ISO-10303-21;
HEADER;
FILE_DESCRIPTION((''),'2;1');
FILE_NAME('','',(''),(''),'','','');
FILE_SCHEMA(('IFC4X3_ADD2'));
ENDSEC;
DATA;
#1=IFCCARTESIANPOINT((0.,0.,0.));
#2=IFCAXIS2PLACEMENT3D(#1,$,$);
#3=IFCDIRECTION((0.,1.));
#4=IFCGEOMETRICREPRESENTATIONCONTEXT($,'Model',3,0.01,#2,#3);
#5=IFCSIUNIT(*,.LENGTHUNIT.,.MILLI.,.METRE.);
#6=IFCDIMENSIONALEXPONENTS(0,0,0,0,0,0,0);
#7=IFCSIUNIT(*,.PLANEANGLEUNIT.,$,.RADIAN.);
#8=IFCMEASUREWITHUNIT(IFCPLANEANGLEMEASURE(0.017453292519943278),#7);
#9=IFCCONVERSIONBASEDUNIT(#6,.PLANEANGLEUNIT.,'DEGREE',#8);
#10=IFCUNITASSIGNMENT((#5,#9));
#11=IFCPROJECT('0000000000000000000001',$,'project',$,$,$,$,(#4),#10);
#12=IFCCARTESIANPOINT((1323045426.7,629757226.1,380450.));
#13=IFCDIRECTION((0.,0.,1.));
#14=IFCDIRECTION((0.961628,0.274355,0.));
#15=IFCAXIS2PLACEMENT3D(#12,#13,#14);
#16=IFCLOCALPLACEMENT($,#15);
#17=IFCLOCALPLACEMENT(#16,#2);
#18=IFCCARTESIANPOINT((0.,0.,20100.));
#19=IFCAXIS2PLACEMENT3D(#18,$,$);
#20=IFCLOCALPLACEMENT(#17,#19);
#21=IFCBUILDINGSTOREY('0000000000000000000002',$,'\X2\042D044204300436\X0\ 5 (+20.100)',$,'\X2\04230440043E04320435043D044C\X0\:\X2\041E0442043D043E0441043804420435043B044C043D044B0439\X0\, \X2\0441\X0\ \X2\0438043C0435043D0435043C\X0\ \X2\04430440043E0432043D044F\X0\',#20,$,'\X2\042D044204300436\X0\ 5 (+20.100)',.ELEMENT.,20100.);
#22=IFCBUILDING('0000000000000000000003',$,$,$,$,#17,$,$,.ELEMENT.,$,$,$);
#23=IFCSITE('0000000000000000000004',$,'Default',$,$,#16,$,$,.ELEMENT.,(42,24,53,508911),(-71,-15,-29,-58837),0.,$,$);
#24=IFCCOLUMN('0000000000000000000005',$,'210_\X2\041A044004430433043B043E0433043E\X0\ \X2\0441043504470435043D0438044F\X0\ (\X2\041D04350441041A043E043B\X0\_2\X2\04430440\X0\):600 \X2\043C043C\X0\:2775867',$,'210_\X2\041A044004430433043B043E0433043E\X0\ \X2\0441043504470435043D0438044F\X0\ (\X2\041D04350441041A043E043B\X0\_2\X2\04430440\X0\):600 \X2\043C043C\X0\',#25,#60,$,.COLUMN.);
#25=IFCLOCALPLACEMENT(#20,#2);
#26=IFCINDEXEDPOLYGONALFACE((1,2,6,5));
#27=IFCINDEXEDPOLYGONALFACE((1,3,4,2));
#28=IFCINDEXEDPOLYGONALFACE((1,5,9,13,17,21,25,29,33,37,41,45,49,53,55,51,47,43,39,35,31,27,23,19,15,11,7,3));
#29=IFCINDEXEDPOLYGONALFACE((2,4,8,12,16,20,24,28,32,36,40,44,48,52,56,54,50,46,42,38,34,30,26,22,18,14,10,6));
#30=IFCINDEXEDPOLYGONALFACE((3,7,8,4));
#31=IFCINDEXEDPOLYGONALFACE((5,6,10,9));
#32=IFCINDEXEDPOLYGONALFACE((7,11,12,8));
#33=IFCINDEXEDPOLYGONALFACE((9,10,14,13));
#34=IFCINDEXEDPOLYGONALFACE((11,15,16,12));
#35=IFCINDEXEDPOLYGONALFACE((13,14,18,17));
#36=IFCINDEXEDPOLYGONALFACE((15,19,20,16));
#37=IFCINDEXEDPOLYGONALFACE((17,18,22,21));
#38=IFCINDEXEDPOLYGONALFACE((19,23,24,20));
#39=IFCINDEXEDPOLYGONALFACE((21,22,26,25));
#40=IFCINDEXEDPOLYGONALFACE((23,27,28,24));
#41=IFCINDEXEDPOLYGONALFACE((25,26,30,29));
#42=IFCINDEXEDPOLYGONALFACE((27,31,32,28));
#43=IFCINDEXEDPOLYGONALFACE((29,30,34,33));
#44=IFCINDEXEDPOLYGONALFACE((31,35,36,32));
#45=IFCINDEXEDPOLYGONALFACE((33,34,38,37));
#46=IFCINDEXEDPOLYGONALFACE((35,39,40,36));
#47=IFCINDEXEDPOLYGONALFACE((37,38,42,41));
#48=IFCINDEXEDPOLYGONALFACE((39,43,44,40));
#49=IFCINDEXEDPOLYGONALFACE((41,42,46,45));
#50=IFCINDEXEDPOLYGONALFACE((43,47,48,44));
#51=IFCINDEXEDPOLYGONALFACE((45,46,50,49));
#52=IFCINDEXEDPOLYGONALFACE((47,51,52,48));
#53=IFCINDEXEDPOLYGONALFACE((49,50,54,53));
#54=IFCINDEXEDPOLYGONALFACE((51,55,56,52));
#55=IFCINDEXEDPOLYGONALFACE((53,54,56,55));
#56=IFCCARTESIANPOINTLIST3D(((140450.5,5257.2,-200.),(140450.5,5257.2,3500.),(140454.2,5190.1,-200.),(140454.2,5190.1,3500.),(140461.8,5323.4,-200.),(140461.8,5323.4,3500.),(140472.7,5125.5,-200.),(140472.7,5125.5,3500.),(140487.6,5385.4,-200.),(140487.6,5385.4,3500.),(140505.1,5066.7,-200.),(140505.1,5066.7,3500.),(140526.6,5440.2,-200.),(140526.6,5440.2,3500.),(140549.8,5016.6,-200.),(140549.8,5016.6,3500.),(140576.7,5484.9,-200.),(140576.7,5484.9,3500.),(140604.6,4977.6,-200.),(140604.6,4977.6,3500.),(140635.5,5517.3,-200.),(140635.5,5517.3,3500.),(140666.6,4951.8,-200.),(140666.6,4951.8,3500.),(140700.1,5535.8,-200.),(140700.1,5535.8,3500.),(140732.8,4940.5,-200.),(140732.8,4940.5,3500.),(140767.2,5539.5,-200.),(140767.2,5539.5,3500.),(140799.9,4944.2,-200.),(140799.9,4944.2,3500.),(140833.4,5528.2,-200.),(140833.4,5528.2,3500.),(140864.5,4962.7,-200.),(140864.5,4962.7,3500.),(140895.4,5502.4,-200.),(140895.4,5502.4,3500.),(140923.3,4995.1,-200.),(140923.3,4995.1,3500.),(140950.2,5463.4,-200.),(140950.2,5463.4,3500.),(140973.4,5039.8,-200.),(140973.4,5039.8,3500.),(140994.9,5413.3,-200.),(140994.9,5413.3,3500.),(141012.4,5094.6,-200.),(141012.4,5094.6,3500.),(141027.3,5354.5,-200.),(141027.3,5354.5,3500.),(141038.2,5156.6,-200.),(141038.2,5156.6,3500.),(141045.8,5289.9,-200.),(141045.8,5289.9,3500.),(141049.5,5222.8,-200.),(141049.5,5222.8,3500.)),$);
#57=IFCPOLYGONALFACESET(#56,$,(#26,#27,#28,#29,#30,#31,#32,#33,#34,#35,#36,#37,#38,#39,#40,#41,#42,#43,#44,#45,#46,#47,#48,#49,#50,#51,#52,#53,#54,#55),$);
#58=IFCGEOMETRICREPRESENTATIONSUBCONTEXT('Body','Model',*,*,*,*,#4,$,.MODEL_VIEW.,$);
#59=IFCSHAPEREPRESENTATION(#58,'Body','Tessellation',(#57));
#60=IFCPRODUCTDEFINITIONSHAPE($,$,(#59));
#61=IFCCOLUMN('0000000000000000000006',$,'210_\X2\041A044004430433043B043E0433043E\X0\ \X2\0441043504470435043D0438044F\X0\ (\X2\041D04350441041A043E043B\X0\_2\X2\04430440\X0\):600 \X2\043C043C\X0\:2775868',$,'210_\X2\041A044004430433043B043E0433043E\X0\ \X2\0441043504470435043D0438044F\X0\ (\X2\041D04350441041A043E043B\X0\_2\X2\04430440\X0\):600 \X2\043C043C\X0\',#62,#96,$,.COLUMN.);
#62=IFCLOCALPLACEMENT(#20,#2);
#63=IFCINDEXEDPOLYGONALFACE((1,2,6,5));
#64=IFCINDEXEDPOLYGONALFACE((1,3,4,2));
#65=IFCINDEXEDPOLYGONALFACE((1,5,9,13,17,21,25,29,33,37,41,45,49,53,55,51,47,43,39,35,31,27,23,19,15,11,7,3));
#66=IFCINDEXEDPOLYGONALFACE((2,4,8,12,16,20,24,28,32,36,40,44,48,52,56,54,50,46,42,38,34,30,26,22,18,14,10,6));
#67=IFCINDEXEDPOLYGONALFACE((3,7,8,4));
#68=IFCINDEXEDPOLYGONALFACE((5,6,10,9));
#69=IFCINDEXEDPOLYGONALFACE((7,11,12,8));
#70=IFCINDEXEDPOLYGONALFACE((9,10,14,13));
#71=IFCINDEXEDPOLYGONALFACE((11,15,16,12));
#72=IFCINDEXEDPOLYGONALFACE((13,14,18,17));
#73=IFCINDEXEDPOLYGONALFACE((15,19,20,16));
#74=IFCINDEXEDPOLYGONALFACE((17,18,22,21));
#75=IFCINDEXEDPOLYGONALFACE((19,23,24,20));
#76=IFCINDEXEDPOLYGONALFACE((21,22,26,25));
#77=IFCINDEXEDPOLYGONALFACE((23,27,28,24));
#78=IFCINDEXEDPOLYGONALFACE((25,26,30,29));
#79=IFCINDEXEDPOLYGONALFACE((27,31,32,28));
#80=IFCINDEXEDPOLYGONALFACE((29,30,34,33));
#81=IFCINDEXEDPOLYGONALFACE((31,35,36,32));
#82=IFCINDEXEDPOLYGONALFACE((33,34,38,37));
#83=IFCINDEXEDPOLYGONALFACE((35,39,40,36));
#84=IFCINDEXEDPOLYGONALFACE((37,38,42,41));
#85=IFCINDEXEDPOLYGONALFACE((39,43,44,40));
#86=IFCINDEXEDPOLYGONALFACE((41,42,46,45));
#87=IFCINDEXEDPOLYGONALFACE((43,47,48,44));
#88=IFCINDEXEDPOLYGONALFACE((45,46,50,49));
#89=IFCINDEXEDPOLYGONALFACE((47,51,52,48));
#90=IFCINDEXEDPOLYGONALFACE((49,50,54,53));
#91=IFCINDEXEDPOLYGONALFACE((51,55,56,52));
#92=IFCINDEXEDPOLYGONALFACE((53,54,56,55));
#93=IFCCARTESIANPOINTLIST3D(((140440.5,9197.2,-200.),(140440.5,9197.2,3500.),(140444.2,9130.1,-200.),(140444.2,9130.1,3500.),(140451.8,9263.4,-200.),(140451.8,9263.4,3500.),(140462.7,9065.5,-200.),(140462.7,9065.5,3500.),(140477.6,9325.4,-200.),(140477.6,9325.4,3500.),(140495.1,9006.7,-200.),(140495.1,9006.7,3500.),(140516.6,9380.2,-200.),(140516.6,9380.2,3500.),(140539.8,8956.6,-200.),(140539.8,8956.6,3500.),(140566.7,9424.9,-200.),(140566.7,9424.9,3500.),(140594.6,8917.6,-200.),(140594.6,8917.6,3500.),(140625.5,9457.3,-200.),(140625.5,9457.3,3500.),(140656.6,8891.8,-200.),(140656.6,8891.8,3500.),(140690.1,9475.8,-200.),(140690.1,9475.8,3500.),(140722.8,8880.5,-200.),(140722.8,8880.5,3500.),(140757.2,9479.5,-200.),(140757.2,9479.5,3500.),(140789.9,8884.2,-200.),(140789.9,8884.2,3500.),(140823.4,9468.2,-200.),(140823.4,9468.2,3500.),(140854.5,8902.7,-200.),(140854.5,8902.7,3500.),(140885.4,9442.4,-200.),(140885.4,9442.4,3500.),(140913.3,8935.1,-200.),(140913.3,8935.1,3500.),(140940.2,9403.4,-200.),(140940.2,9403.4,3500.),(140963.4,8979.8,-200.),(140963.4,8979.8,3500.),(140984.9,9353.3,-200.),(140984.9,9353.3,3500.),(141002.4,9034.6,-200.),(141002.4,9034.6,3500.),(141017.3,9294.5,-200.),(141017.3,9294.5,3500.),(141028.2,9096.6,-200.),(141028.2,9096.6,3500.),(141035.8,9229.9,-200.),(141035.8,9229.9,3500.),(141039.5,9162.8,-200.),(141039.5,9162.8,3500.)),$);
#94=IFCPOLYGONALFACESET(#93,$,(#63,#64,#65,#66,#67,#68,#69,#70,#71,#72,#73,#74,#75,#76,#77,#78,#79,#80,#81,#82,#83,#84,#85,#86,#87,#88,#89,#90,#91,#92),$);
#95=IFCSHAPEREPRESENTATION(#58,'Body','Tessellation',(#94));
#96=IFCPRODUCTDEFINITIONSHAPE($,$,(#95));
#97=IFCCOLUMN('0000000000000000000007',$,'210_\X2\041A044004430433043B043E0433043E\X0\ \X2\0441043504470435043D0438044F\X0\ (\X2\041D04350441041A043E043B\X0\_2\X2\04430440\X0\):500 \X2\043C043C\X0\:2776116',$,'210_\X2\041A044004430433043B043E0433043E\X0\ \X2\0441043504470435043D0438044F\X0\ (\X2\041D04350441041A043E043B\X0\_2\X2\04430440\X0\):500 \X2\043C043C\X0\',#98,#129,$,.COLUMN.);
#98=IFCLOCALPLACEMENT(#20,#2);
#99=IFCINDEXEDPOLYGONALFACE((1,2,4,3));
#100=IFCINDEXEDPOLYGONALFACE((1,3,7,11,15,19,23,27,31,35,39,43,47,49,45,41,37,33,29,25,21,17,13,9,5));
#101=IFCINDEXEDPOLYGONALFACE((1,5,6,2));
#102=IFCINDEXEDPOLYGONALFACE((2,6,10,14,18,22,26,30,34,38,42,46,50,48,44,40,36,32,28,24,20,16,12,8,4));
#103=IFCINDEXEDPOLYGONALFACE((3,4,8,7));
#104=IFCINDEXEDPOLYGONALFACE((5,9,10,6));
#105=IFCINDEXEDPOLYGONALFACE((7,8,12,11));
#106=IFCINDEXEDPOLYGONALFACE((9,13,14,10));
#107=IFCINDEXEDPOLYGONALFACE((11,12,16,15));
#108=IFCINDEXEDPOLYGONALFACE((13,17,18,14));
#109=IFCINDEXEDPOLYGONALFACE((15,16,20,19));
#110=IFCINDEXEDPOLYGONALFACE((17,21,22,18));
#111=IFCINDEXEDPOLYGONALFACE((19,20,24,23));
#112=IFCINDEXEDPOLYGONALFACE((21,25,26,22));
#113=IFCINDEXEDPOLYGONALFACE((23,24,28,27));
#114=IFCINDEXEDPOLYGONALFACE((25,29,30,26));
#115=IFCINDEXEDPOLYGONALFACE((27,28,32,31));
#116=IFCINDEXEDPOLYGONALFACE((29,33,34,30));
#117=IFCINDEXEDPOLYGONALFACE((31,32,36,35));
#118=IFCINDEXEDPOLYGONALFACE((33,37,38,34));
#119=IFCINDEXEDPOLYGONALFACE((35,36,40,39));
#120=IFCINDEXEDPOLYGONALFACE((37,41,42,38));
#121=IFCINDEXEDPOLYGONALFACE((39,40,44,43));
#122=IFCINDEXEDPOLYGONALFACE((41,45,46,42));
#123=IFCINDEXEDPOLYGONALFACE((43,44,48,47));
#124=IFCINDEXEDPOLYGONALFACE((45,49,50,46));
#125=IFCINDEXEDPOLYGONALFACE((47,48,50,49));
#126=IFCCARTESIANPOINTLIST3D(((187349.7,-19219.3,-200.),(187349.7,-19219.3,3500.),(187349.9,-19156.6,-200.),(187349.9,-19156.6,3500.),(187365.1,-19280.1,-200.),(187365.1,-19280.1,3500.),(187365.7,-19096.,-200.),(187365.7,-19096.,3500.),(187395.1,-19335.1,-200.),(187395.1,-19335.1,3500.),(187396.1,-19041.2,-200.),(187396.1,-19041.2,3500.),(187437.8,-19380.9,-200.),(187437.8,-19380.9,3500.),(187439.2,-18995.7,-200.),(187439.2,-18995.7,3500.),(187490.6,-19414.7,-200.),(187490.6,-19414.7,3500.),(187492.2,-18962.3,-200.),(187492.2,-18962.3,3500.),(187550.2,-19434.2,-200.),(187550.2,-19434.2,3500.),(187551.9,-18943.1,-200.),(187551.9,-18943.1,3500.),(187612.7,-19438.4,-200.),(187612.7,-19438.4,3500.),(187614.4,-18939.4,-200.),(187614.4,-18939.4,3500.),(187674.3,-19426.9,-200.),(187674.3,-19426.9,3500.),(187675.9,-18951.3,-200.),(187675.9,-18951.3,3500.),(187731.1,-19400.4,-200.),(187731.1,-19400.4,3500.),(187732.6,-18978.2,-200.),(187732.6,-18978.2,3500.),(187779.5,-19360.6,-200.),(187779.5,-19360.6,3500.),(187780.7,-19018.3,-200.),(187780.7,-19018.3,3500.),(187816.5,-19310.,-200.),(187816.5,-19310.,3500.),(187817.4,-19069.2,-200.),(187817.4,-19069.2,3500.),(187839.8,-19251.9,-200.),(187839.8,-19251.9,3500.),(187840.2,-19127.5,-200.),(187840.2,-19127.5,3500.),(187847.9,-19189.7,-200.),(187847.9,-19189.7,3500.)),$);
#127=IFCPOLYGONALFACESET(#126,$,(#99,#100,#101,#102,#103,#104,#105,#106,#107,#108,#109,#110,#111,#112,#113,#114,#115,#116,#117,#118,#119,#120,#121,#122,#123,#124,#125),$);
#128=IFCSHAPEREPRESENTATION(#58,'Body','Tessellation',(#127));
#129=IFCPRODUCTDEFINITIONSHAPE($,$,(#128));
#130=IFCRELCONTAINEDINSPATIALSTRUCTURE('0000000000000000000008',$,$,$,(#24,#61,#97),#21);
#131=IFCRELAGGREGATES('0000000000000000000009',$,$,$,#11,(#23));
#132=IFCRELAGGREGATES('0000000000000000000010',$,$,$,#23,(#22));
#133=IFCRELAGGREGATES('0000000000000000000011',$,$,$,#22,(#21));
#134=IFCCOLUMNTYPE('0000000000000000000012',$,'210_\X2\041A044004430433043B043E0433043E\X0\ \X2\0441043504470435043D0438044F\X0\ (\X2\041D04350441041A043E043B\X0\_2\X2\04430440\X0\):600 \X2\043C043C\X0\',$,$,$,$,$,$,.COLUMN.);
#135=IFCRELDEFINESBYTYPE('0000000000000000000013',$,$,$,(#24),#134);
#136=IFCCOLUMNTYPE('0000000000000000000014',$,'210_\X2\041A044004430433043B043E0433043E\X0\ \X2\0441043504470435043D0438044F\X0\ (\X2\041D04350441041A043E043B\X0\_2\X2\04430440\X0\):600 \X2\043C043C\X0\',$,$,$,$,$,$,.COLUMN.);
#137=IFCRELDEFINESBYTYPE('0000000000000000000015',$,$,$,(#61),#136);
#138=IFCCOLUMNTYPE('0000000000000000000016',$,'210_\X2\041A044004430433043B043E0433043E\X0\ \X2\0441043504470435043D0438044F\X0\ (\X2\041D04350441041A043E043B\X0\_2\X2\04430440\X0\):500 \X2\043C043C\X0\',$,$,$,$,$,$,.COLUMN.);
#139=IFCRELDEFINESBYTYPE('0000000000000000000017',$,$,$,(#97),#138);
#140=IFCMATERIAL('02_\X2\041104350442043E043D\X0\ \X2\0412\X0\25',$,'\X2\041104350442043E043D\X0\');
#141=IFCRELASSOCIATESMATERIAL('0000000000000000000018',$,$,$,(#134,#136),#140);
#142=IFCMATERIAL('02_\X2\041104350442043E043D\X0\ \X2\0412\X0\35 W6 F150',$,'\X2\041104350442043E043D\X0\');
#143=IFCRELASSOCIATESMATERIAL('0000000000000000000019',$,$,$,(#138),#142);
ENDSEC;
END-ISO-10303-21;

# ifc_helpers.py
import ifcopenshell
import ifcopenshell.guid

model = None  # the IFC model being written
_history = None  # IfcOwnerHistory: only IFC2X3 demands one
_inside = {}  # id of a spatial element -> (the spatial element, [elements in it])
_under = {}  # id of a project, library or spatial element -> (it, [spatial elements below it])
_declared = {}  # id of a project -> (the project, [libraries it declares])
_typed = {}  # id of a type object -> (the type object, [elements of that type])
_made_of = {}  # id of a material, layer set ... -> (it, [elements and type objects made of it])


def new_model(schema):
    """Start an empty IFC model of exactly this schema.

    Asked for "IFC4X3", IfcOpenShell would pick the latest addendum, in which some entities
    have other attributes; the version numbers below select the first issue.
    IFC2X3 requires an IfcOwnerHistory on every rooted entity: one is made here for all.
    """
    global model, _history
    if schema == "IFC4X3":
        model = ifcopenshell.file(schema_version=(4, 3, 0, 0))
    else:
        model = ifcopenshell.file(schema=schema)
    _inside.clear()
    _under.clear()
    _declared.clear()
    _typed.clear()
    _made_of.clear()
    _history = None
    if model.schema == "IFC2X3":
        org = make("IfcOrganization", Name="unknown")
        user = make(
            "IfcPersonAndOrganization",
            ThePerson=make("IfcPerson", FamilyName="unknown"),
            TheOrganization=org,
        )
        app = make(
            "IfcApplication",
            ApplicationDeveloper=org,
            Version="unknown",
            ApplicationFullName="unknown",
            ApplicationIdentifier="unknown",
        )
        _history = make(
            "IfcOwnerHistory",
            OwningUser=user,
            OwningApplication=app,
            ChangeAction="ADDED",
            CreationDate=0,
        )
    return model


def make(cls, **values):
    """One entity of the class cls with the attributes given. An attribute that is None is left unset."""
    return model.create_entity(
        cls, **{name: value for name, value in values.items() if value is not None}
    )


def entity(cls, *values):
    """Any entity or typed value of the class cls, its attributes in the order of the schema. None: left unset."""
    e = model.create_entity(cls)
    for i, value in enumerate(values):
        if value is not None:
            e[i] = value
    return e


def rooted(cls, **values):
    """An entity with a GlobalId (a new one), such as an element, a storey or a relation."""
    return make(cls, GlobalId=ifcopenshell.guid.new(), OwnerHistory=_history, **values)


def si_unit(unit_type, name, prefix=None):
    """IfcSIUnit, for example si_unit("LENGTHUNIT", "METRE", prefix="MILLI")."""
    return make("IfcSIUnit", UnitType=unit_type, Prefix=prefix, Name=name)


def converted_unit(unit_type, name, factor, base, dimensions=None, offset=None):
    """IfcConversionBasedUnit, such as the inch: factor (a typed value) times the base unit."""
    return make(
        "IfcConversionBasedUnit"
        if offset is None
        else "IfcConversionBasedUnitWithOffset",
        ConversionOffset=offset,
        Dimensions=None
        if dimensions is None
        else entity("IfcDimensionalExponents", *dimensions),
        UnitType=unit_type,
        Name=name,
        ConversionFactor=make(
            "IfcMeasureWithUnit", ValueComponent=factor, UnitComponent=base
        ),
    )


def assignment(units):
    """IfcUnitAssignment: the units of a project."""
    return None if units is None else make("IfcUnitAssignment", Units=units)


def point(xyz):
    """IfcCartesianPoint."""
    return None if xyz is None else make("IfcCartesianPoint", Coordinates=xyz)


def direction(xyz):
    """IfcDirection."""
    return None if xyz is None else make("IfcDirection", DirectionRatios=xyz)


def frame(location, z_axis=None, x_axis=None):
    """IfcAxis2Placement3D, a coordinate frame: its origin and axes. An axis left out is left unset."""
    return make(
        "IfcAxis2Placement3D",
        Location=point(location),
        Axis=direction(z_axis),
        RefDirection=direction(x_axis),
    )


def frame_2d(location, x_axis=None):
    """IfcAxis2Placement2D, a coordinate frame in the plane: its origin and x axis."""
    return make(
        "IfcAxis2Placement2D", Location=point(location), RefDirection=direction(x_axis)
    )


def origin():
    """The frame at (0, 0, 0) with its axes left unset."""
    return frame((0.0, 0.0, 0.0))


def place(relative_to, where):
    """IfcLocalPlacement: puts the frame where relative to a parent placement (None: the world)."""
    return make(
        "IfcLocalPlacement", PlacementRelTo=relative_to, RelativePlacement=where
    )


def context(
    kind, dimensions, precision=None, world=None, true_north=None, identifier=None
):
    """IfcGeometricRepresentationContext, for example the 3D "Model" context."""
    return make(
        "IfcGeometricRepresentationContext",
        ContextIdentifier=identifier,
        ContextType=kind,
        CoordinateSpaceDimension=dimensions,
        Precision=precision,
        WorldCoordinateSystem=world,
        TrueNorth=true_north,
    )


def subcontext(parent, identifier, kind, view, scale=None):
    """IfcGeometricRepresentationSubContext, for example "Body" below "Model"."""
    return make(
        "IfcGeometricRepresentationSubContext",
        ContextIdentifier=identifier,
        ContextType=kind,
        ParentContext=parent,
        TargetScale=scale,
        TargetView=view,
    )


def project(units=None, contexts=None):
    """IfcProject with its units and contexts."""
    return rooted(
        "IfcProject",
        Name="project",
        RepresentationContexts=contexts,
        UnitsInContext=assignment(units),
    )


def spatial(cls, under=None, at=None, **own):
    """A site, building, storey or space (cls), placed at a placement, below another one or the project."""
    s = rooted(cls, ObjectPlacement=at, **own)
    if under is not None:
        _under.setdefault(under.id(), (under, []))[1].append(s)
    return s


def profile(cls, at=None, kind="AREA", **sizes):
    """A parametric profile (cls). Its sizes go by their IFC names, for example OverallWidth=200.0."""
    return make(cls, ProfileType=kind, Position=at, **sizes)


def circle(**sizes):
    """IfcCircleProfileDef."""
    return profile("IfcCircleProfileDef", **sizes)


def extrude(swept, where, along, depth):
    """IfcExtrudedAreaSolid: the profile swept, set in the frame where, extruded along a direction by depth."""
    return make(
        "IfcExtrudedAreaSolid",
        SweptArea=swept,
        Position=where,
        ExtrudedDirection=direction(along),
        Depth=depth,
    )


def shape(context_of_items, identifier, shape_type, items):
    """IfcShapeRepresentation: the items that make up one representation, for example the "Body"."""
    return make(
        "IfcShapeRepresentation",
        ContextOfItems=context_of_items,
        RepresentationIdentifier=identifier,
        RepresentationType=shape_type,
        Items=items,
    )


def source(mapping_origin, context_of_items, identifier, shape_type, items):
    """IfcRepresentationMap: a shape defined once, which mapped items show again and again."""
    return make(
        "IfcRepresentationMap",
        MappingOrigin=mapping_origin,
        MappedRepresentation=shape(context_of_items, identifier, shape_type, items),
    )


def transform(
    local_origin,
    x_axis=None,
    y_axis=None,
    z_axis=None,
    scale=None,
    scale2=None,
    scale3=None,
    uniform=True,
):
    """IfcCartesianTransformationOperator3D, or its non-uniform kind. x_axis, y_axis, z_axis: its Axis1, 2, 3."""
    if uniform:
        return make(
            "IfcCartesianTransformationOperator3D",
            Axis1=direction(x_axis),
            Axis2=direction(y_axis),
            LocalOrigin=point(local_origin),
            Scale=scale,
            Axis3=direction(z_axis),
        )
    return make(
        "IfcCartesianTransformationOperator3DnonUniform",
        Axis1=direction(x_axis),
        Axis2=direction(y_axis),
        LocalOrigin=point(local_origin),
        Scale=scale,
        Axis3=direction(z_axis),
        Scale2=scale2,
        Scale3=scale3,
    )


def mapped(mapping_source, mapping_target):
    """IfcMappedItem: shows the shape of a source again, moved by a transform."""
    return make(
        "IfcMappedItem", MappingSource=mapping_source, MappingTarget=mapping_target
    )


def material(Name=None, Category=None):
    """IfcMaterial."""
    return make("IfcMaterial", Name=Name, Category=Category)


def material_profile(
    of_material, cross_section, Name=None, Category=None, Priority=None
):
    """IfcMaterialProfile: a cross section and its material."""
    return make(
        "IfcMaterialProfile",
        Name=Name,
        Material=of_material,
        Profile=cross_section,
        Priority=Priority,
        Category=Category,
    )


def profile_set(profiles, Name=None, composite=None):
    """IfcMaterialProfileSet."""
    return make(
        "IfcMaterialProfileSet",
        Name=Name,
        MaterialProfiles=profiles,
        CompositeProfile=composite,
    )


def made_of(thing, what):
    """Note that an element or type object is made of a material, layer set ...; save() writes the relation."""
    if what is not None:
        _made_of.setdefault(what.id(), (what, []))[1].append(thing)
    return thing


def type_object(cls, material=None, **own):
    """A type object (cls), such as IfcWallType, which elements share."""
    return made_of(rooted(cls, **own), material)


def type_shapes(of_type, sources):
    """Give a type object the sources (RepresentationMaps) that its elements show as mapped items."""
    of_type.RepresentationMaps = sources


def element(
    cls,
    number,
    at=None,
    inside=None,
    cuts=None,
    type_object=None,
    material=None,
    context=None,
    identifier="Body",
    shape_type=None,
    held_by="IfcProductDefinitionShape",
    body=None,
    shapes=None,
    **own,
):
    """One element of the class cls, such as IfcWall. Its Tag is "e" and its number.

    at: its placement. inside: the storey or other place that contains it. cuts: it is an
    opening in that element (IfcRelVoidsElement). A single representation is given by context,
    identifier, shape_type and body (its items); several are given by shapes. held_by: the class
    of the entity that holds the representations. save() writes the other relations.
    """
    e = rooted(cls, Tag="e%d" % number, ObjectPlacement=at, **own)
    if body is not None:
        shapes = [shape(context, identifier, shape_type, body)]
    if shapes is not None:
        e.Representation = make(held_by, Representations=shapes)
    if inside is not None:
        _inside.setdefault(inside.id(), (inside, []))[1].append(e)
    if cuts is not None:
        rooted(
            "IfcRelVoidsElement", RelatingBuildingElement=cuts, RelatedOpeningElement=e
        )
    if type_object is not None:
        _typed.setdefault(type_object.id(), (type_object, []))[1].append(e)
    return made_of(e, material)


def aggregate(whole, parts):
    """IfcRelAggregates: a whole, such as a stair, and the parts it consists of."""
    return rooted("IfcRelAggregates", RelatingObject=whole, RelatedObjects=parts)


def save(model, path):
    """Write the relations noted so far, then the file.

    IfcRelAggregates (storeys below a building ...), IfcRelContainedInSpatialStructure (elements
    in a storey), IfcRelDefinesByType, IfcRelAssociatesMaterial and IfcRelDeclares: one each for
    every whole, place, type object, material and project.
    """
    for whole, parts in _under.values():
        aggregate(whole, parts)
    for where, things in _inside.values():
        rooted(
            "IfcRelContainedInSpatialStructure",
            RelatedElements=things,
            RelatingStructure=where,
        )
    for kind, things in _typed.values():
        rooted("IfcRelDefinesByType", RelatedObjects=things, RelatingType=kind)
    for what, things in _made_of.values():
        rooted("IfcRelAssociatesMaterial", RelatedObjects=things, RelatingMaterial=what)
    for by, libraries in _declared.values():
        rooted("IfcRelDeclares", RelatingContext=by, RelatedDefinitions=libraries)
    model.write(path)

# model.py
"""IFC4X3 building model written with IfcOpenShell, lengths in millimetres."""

from ifc_helpers import new_model, entity, si_unit, converted_unit, direction, frame, frame_2d, origin, place, context, subcontext, project, spatial, circle, extrude, source, transform, mapped, material, material_profile, profile_set, type_object, type_shapes, element, save


model = new_model("IFC4X3")

# Units and contexts
model_context = context("Model", 3, precision=0.01, world=origin(), true_north=direction((0.0, 1.0)))
body_context = subcontext(model_context, "Body", "Model", "MODEL_VIEW")
ifc_project = project(units=[si_unit("LENGTHUNIT", "METRE", prefix="MILLI"), converted_unit("PLANEANGLEUNIT", "DEGREE", entity("IfcPlaneAngleMeasure", 0.017453292519943278), si_unit("PLANEANGLEUNIT", "RADIAN"), dimensions=[0, 0, 0, 0, 0, 0, 0])], contexts=[model_context])

# Site, building, storey
site_placement = place(None, frame((1323045426.7, 629757226.1, 380450.0), z_axis=(0.0, 0.0, 1.0), x_axis=(0.961628, 0.274355, 0.0)))
site = spatial("IfcSite", under=ifc_project, at=site_placement, Name="Default", CompositionType="ELEMENT", RefLatitude=(42, 24, 53, 508911), RefLongitude=(-71, -15, -29, -58837), RefElevation=0.0)
building_placement = place(site_placement, origin())
building = spatial("IfcBuilding", under=site, at=building_placement, CompositionType="ELEMENT")
storey_placement = place(building_placement, frame((0.0, 0.0, 20100.0)))
storey = spatial("IfcBuildingStorey", under=building, at=storey_placement, Name="Этаж 5 (+20.100)", ObjectType="Уровень:Относительный, с именем уровня", LongName="Этаж 5 (+20.100)", CompositionType="ELEMENT", Elevation=20100.0)

# Columns
ifc_material_1 = material(Name="02_Бетон В35 W6 F150", Category="Бетон")
ifc_material_profile_1 = material_profile(ifc_material_1, circle(Radius=250.0, at=frame_2d((0.0, 0.0), x_axis=(1.0, 0.0))), Name="500 мм")
ifc_profile_set_1 = profile_set([ifc_material_profile_1], Name="500 мм")
ifc_material_2 = material(Name="02_Бетон В25", Category="Бетон")
ifc_material_profile_2 = material_profile(ifc_material_2, circle(Radius=300.0, at=frame_2d((0.0, 0.0), x_axis=(1.0, 0.0))), Name="600 мм")
ifc_profile_set_2 = profile_set([ifc_material_profile_2], Name="600 мм")
column_type_1 = type_object("IfcColumnType", Name="210_Круглого сечения (НесКол_2ур):600 мм", PredefinedType="COLUMN", material=ifc_profile_set_2)
shared_shape_1 = source(origin(), body_context, "Body", "SweptSolid", [
    extrude(circle(Radius=300.0, at=frame_2d((0.0, 0.0), x_axis=(1.0, 0.0))), frame((140750.0, 5240.0, 19900.0), z_axis=(0.0, 0.0, 1.0), x_axis=(0.87462, -0.48481, 0.0)), (0.0, 0.0, 1.0), 3700.0),
])
type_shapes(column_type_1, [shared_shape_1])
column_1_placement = place(storey_placement, frame((0.0, 0.0, -20100.0)))
element("IfcColumn", 1, at=column_1_placement, inside=storey, type_object=column_type_1, Name="210_Круглого сечения (НесКол_2ур):600 мм:2775867", ObjectType="210_Круглого сечения (НесКол_2ур):600 мм", PredefinedType="COLUMN", context=body_context, shape_type="MappedRepresentation", body=[
    mapped(shared_shape_1, transform((0.0, 0.0, 0.0), scale=1.0)),
])
column_type_2 = type_object("IfcColumnType", Name="210_Круглого сечения (НесКол_2ур):600 мм", PredefinedType="COLUMN", material=ifc_profile_set_2)
shared_shape_2 = source(origin(), body_context, "Body", "SweptSolid", [
    extrude(circle(Radius=300.0, at=frame_2d((0.0, 0.0), x_axis=(1.0, 0.0))), frame((140740.0, 9180.0, 19900.0), z_axis=(0.0, 0.0, 1.0), x_axis=(0.87462, -0.48481, 0.0)), (0.0, 0.0, 1.0), 3700.0),
])
type_shapes(column_type_2, [shared_shape_2])
column_2_placement = place(storey_placement, frame((0.0, 0.0, -20100.0)))
element("IfcColumn", 2, at=column_2_placement, inside=storey, type_object=column_type_2, Name="210_Круглого сечения (НесКол_2ур):600 мм:2775868", ObjectType="210_Круглого сечения (НесКол_2ур):600 мм", PredefinedType="COLUMN", context=body_context, shape_type="MappedRepresentation", body=[
    mapped(shared_shape_2, transform((0.0, 0.0, 0.0), scale=1.0)),
])
column_type_3 = type_object("IfcColumnType", Name="210_Круглого сечения (НесКол_2ур):500 мм", PredefinedType="COLUMN", material=ifc_profile_set_1)
shared_shape_3 = source(origin(), body_context, "Body", "SweptSolid", [
    extrude(circle(Radius=250.0, at=frame_2d((0.0, 0.0), x_axis=(1.0, 0.0))), frame((187597.9, -19188.8, 19900.0), z_axis=(0.0, 0.0, 1.0), x_axis=(0.87462, -0.48481, 0.0)), (0.0, 0.0, 1.0), 3700.0),
])
type_shapes(column_type_3, [shared_shape_3])
column_3_placement = place(storey_placement, frame((0.0, 0.0, -20100.0)))
element("IfcColumn", 3, at=column_3_placement, inside=storey, type_object=column_type_3, Name="210_Круглого сечения (НесКол_2ур):500 мм:2776116", ObjectType="210_Круглого сечения (НесКол_2ур):500 мм", PredefinedType="COLUMN", context=body_context, shape_type="MappedRepresentation", body=[
    mapped(shared_shape_3, transform((0.0, 0.0, 0.0), scale=1.0)),
])

save(model, "model.ifc")
